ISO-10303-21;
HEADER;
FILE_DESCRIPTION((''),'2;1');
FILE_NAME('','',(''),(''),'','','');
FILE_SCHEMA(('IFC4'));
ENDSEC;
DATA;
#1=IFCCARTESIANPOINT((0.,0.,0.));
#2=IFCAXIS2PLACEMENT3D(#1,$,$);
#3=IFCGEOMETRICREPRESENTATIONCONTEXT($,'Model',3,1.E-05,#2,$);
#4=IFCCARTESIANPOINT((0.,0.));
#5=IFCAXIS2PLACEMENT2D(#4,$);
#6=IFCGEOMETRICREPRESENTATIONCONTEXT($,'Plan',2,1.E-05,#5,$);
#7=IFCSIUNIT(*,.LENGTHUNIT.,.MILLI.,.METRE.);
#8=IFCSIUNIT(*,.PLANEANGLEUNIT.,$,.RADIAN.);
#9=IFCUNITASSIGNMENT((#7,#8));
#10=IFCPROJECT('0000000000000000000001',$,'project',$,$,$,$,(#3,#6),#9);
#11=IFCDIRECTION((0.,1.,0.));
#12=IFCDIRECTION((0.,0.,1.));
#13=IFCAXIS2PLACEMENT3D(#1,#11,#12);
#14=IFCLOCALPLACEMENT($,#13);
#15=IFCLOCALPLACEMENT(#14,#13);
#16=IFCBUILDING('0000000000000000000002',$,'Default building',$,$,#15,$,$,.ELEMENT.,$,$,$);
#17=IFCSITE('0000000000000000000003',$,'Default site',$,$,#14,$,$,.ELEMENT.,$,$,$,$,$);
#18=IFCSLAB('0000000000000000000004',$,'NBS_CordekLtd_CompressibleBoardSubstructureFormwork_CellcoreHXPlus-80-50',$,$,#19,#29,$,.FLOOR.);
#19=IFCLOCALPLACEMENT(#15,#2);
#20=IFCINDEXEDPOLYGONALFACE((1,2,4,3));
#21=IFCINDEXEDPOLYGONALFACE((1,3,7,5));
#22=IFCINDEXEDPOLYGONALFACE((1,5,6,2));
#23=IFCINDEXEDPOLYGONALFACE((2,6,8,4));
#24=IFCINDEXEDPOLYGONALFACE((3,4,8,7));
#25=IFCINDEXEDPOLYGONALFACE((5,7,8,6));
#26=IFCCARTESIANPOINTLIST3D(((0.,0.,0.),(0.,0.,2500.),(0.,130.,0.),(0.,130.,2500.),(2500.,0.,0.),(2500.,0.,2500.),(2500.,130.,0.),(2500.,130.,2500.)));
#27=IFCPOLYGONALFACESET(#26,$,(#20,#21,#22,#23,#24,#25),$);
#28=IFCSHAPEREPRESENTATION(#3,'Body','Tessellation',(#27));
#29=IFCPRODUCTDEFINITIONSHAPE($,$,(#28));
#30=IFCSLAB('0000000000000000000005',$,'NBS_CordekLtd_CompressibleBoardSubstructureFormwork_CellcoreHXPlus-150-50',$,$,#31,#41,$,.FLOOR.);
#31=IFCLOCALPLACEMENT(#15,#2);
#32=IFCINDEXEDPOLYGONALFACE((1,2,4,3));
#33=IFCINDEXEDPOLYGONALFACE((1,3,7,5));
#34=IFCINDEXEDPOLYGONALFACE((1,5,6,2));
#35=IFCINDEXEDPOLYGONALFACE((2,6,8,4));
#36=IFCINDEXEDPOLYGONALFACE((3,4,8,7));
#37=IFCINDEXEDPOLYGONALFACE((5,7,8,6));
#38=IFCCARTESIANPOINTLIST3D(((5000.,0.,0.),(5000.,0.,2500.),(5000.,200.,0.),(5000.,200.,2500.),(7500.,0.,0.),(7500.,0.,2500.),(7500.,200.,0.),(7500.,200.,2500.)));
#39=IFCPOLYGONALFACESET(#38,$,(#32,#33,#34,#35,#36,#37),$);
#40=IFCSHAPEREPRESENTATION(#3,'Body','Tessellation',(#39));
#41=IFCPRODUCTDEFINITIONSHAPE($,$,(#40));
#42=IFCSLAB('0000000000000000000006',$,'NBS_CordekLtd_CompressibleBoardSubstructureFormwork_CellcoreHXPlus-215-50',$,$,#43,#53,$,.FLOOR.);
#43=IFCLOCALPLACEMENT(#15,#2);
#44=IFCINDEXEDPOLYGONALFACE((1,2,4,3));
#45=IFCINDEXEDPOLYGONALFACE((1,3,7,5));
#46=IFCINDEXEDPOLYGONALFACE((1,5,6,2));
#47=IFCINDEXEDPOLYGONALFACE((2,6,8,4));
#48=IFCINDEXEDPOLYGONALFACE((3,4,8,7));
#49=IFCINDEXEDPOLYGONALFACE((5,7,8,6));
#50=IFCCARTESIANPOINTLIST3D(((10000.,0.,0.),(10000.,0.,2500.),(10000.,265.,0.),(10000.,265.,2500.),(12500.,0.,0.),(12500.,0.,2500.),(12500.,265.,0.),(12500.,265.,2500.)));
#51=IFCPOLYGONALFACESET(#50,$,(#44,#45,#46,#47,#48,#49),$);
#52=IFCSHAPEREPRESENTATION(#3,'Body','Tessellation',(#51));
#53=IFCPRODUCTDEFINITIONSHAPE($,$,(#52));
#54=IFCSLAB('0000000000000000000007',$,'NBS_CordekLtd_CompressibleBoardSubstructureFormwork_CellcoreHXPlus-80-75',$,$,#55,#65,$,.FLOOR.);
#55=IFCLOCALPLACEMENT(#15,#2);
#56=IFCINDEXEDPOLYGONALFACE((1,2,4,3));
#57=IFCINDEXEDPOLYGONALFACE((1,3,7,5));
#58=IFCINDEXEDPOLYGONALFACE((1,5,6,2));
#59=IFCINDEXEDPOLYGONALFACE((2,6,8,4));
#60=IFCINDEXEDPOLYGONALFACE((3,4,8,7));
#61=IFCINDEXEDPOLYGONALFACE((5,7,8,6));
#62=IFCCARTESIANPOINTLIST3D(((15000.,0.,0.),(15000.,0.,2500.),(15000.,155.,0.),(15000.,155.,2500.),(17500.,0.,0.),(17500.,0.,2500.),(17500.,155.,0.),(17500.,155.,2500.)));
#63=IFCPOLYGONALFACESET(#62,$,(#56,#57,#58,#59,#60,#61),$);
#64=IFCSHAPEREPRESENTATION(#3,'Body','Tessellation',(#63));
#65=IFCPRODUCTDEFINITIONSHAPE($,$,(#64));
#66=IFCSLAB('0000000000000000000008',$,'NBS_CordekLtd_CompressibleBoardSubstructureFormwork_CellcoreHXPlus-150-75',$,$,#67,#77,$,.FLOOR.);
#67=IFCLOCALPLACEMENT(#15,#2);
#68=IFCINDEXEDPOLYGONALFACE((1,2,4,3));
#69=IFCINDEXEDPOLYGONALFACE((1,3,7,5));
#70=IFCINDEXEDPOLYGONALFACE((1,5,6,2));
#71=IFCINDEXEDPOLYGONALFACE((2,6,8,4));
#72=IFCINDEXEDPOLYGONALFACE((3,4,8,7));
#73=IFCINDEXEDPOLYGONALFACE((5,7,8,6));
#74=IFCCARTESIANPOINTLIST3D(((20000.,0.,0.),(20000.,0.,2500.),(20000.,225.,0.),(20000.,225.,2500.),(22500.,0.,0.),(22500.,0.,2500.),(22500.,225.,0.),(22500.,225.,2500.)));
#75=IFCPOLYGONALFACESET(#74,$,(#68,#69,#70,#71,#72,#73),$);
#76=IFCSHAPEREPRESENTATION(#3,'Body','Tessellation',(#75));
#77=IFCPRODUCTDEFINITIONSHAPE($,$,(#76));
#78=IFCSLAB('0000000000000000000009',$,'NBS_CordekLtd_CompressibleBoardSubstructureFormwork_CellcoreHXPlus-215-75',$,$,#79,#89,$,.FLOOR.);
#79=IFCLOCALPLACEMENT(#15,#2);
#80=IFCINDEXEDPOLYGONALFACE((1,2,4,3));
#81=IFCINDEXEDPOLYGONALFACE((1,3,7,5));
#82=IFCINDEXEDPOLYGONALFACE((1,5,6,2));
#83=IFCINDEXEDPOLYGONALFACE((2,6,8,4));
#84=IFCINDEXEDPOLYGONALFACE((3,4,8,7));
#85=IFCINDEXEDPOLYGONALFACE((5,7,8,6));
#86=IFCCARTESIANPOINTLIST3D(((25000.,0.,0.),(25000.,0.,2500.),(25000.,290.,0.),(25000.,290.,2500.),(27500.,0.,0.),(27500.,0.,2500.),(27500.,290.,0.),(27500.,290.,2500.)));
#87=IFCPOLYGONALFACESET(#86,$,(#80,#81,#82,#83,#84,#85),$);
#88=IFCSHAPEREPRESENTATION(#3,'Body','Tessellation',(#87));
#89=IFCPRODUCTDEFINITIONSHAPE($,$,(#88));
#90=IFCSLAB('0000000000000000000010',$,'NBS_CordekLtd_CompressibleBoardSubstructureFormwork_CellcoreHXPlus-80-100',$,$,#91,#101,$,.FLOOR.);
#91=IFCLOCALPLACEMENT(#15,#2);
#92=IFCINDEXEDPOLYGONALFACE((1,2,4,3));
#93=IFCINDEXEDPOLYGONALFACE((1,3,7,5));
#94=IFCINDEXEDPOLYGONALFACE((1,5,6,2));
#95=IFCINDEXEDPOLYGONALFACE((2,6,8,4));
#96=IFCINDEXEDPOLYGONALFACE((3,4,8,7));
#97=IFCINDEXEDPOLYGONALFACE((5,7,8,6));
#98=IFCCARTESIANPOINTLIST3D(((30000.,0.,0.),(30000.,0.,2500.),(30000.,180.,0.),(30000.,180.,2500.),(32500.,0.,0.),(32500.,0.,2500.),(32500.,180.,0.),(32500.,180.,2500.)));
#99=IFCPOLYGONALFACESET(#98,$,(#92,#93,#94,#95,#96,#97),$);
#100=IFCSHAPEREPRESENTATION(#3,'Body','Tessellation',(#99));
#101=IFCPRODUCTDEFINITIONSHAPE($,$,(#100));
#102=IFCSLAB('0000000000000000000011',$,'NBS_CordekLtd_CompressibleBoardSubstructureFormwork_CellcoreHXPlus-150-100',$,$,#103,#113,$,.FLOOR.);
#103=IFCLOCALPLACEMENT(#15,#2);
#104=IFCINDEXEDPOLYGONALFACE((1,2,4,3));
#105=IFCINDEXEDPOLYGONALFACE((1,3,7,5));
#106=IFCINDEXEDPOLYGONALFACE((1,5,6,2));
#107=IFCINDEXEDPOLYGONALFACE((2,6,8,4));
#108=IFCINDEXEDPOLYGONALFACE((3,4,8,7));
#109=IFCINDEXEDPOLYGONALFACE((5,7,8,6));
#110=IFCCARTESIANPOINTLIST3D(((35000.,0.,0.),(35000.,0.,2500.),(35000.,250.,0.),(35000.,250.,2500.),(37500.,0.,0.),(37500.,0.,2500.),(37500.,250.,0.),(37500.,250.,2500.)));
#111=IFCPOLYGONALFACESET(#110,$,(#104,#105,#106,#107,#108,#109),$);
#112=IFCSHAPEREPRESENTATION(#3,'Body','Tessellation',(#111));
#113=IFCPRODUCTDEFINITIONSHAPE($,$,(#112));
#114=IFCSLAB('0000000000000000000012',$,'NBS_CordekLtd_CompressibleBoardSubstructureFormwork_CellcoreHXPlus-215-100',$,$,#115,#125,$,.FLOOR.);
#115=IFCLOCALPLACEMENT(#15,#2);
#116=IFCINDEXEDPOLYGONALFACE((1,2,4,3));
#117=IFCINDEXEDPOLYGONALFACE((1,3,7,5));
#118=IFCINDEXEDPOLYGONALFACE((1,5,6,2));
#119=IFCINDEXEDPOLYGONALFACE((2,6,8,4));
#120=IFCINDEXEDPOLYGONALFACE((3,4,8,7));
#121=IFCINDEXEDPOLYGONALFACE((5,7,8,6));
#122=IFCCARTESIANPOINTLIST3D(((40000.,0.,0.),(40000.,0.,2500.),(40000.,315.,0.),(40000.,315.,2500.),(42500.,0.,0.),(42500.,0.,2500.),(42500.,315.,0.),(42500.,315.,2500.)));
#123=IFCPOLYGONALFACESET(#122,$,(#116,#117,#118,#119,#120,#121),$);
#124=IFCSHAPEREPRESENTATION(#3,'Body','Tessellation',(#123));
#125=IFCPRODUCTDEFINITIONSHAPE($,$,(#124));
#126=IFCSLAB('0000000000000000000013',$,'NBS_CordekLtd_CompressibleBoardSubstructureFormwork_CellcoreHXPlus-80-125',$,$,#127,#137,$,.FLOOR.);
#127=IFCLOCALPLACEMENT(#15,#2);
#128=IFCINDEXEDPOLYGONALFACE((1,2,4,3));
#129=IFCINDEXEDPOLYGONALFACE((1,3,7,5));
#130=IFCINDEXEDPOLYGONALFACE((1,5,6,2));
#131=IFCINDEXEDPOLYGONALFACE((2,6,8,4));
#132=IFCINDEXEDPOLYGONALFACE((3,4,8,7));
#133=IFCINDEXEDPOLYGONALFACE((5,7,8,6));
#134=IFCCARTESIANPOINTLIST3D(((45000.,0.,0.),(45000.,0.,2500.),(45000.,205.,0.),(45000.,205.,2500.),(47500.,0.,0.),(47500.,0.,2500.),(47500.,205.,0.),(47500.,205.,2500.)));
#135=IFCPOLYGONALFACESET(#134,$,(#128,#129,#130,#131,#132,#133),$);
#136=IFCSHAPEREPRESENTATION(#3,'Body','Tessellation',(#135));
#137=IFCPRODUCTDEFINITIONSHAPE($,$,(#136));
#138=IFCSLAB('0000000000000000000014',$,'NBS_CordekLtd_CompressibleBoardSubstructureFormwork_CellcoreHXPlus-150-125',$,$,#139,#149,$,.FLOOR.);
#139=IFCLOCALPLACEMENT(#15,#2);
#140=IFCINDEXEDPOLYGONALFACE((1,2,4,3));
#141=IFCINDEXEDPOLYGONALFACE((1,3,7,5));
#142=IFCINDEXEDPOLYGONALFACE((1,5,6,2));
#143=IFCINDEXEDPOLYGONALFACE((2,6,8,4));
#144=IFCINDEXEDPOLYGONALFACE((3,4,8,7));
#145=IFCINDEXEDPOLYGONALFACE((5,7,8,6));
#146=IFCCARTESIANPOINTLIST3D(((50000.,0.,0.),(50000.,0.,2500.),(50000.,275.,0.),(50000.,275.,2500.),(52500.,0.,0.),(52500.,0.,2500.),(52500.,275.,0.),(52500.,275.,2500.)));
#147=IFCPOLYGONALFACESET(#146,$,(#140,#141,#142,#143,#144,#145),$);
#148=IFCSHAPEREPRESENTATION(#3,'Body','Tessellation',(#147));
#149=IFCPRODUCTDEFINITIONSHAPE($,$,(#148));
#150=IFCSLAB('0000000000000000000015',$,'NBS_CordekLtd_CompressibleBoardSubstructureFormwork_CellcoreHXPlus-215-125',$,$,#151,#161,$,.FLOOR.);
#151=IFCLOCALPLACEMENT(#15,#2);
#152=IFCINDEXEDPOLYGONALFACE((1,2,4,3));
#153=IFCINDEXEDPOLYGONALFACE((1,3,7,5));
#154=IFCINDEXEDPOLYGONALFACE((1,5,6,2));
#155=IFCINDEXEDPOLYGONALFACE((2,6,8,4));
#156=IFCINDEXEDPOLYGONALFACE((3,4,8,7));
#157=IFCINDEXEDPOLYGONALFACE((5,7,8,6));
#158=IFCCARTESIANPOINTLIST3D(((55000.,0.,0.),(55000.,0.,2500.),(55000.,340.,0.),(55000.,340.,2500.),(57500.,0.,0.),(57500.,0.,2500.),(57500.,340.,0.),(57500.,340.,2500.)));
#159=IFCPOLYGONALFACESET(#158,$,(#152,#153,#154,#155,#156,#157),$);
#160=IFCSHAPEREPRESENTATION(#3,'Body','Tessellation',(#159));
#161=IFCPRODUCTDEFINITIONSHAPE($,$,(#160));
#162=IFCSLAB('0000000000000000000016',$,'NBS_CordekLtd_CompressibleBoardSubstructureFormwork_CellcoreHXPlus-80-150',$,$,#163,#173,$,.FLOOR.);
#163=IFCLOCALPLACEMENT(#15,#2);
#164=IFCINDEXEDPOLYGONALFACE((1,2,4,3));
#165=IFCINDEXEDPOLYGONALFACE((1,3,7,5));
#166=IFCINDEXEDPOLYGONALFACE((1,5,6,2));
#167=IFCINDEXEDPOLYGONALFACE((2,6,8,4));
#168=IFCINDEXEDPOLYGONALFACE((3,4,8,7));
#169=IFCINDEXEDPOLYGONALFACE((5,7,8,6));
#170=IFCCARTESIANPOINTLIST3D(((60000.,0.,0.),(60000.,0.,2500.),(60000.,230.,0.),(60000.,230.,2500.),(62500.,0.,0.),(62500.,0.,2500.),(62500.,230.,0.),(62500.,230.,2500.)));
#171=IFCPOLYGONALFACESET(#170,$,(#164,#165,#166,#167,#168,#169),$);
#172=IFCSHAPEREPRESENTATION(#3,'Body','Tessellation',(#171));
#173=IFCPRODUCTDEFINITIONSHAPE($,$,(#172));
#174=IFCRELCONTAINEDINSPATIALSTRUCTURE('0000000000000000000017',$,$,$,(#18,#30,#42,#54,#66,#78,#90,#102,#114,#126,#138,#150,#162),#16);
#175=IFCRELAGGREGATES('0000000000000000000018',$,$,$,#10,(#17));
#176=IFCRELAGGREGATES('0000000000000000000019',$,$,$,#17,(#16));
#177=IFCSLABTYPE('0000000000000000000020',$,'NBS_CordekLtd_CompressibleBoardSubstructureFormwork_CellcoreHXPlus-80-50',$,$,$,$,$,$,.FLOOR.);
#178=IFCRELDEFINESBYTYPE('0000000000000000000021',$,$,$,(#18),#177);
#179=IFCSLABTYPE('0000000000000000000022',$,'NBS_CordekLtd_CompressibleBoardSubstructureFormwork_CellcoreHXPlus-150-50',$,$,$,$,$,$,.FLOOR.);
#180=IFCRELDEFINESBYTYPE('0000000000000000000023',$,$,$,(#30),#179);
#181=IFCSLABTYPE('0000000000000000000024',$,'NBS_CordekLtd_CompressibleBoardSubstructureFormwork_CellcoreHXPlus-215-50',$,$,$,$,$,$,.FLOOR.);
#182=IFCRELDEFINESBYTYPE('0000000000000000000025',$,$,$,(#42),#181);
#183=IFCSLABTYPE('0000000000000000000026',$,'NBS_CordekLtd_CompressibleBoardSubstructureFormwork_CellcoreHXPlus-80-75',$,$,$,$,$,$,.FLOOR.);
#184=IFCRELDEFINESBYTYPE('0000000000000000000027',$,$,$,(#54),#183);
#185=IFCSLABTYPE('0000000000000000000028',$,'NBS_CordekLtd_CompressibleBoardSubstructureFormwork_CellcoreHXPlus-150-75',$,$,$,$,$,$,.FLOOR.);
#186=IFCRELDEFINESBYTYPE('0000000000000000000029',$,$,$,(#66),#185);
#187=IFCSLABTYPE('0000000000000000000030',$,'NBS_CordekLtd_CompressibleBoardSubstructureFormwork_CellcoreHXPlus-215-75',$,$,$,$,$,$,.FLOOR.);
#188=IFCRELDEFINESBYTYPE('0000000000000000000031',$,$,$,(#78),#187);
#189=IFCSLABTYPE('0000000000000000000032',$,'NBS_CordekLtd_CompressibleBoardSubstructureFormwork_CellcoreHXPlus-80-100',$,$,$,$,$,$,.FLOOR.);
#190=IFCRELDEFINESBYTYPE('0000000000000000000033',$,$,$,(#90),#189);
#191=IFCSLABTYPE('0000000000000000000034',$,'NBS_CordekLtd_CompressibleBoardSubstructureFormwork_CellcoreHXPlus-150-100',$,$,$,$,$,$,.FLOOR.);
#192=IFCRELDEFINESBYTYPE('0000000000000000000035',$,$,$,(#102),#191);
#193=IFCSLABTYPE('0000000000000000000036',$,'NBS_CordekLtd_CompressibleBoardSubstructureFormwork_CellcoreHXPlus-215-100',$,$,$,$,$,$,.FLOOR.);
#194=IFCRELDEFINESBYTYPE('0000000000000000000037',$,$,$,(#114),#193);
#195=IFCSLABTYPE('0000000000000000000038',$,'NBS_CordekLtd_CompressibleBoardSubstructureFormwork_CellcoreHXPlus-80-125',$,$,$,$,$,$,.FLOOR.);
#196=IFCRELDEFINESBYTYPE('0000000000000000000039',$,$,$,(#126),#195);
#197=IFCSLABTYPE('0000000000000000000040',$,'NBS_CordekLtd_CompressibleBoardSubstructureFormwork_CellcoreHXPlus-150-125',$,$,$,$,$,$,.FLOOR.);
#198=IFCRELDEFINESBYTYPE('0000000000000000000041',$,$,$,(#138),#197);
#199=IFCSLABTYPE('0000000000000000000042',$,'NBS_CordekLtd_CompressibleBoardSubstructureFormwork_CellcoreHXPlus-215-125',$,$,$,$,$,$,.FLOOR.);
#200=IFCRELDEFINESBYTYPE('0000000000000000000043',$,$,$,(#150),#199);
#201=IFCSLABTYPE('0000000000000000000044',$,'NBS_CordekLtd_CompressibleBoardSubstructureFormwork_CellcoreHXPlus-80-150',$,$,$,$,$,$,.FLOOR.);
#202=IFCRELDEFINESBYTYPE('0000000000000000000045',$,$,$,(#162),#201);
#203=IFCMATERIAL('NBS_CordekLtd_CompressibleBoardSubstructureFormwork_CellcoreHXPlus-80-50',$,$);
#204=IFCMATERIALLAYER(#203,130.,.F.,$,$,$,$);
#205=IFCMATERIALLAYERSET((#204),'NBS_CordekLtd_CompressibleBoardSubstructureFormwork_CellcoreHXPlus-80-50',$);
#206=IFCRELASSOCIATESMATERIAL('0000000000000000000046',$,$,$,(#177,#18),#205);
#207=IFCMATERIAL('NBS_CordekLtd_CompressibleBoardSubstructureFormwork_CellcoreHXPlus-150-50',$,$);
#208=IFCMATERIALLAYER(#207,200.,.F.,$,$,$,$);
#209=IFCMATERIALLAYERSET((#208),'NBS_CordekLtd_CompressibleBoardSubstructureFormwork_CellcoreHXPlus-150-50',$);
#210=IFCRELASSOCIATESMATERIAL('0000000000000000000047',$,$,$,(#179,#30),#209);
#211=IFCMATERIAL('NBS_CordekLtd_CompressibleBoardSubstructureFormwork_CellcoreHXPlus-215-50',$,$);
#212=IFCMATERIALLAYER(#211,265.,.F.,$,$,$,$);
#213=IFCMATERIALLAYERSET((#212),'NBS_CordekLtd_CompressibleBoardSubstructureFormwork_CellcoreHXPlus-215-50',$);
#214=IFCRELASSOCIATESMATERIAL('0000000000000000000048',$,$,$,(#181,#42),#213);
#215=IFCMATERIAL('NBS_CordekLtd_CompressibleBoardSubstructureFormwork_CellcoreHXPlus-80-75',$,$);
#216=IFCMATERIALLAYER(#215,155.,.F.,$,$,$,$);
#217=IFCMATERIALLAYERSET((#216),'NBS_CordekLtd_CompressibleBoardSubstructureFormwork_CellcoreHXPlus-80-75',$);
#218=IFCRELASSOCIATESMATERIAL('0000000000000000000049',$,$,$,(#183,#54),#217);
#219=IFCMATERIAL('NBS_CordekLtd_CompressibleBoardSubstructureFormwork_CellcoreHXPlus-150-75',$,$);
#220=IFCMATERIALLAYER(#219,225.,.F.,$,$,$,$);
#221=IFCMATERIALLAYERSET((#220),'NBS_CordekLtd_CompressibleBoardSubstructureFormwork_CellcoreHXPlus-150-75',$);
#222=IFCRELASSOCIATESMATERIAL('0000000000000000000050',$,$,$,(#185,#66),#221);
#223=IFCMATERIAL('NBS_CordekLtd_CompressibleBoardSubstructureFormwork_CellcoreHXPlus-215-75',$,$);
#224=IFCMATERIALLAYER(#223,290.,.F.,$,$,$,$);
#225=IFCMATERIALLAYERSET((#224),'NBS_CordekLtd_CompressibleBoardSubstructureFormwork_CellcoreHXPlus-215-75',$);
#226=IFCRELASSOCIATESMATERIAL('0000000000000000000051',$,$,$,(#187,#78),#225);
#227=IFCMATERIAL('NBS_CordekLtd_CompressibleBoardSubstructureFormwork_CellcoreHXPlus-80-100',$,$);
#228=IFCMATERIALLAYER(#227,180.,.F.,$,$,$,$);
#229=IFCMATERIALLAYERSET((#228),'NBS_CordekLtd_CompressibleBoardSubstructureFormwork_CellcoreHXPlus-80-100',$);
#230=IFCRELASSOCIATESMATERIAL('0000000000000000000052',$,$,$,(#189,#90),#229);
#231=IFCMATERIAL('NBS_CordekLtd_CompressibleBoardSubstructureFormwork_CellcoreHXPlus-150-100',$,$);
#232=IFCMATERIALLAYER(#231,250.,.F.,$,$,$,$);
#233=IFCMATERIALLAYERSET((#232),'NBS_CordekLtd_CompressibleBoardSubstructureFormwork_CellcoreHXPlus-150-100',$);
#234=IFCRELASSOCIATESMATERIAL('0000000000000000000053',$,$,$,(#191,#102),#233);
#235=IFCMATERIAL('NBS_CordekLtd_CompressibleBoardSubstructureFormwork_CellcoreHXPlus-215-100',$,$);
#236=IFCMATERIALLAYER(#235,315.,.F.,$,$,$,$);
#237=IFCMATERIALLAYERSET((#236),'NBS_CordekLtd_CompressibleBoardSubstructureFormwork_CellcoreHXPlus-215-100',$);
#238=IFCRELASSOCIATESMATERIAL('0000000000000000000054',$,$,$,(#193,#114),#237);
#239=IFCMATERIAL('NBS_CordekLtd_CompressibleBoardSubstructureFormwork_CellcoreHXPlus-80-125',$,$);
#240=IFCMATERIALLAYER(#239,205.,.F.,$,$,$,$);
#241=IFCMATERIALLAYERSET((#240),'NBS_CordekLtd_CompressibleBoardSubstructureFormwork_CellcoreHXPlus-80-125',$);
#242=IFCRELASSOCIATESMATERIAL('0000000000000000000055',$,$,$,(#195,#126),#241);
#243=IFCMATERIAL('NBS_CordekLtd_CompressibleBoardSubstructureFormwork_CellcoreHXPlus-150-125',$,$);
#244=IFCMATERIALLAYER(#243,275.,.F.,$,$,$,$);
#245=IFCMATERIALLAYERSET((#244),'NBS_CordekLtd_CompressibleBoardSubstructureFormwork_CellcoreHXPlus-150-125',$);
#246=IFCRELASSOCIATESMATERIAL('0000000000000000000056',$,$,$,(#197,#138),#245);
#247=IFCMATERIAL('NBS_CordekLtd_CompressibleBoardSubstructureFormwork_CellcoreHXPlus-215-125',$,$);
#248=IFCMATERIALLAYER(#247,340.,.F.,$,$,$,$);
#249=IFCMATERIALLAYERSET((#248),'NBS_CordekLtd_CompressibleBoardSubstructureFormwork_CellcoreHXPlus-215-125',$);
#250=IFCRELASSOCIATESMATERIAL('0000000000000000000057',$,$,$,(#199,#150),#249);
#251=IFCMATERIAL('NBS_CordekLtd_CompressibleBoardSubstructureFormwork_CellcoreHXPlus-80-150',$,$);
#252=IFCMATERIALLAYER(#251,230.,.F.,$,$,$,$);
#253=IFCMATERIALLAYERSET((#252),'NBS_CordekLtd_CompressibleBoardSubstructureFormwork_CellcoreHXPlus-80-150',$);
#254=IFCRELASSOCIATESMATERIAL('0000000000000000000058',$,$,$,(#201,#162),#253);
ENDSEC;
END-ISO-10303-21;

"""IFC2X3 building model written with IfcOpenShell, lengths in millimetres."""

from ifc_helpers import new_model, si_unit, frame, frame_2d, origin, origin_with_axes, origin_2d, place, context, project, spatial, rectangle, extrude, material, layer, layer_set, layer_usage, type_object, element, save


model = new_model("IFC2X3")

# Units and contexts
model_context = context("Model", 3, precision=1e-05, world=origin())
plan_context = context("Plan", 2, precision=1e-05, world=origin_2d())
ifc_project = project(units=[si_unit("LENGTHUNIT", "METRE", prefix="MILLI"), si_unit("PLANEANGLEUNIT", "RADIAN")], contexts=[model_context, plan_context])

# Site, building
site_placement = place(None, frame((0.0, 0.0, 0.0), z_axis=(0.0, 1.0, 0.0), x_axis=(0.0, 0.0, 1.0)))
site = spatial("IfcSite", under=ifc_project, at=site_placement, Name="Default site", CompositionType="ELEMENT")
building_placement = place(site_placement, frame((0.0, 0.0, 0.0), z_axis=(0.0, 1.0, 0.0), x_axis=(0.0, 0.0, 1.0)))
building = spatial("IfcBuilding", under=site, at=building_placement, Name="Default building", CompositionType="ELEMENT")

# Slabs
ifc_material_1 = material(Name="NBS_CordekLtd_CompressibleBoardSubstructureFormwork_CellcoreHXPlus-80-50")
ifc_layer_1 = layer(ifc_material_1, 130.0, ventilated=False)
ifc_layer_set_1 = layer_set([ifc_layer_1], Name="NBS_CordekLtd_CompressibleBoardSubstructureFormwork_CellcoreHXPlus-80-50")
ifc_layer_usage_1 = layer_usage(ifc_layer_set_1, "AXIS3", "NEGATIVE", 0.0)
slab_type_1 = type_object("IfcSlabType", Name="NBS_CordekLtd_CompressibleBoardSubstructureFormwork_CellcoreHXPlus-80-50", PredefinedType="FLOOR", material=ifc_layer_set_1)
slab_1_placement = place(None, origin())
element("IfcSlab", 1, at=slab_1_placement, inside=building, type_object=slab_type_1, material=ifc_layer_usage_1, Name="NBS_CordekLtd_CompressibleBoardSubstructureFormwork_CellcoreHXPlus-80-50", PredefinedType="FLOOR", context=model_context, shape_type="SweptSolid", body=[
    extrude(rectangle(XDim=2500.0, YDim=2500.0, at=frame_2d((1250.0, 1250.0))), origin_with_axes(), (0.0, 0.0, 1.0), 130.0),
])
ifc_material_2 = material(Name="NBS_CordekLtd_CompressibleBoardSubstructureFormwork_CellcoreHXPlus-150-50")
ifc_layer_2 = layer(ifc_material_2, 200.0, ventilated=False)
ifc_layer_set_2 = layer_set([ifc_layer_2], Name="NBS_CordekLtd_CompressibleBoardSubstructureFormwork_CellcoreHXPlus-150-50")
ifc_layer_usage_2 = layer_usage(ifc_layer_set_2, "AXIS3", "NEGATIVE", 0.0)
slab_type_2 = type_object("IfcSlabType", Name="NBS_CordekLtd_CompressibleBoardSubstructureFormwork_CellcoreHXPlus-150-50", PredefinedType="FLOOR", material=ifc_layer_set_2)
slab_2_placement = place(None, frame((0.0, 5000.0, 0.0)))
element("IfcSlab", 2, at=slab_2_placement, inside=building, type_object=slab_type_2, material=ifc_layer_usage_2, Name="NBS_CordekLtd_CompressibleBoardSubstructureFormwork_CellcoreHXPlus-150-50", PredefinedType="FLOOR", context=model_context, shape_type="SweptSolid", body=[
    extrude(rectangle(XDim=2500.0, YDim=2500.0, at=frame_2d((1250.0, 1250.0))), origin_with_axes(), (0.0, 0.0, 1.0), 200.0),
])
ifc_material_3 = material(Name="NBS_CordekLtd_CompressibleBoardSubstructureFormwork_CellcoreHXPlus-215-50")
ifc_layer_3 = layer(ifc_material_3, 265.0, ventilated=False)
ifc_layer_set_3 = layer_set([ifc_layer_3], Name="NBS_CordekLtd_CompressibleBoardSubstructureFormwork_CellcoreHXPlus-215-50")
ifc_layer_usage_3 = layer_usage(ifc_layer_set_3, "AXIS3", "NEGATIVE", 0.0)
slab_type_3 = type_object("IfcSlabType", Name="NBS_CordekLtd_CompressibleBoardSubstructureFormwork_CellcoreHXPlus-215-50", PredefinedType="FLOOR", material=ifc_layer_set_3)
slab_3_placement = place(None, frame((0.0, 10000.0, 0.0)))
element("IfcSlab", 3, at=slab_3_placement, inside=building, type_object=slab_type_3, material=ifc_layer_usage_3, Name="NBS_CordekLtd_CompressibleBoardSubstructureFormwork_CellcoreHXPlus-215-50", PredefinedType="FLOOR", context=model_context, shape_type="SweptSolid", body=[
    extrude(rectangle(XDim=2500.0, YDim=2500.0, at=frame_2d((1250.0, 1250.0))), origin_with_axes(), (0.0, 0.0, 1.0), 265.0),
])
ifc_material_4 = material(Name="NBS_CordekLtd_CompressibleBoardSubstructureFormwork_CellcoreHXPlus-80-75")
ifc_layer_4 = layer(ifc_material_4, 155.0, ventilated=False)
ifc_layer_set_4 = layer_set([ifc_layer_4], Name="NBS_CordekLtd_CompressibleBoardSubstructureFormwork_CellcoreHXPlus-80-75")
ifc_layer_usage_4 = layer_usage(ifc_layer_set_4, "AXIS3", "NEGATIVE", 0.0)
slab_type_4 = type_object("IfcSlabType", Name="NBS_CordekLtd_CompressibleBoardSubstructureFormwork_CellcoreHXPlus-80-75", PredefinedType="FLOOR", material=ifc_layer_set_4)
slab_4_placement = place(None, frame((0.0, 15000.0, 0.0)))
element("IfcSlab", 4, at=slab_4_placement, inside=building, type_object=slab_type_4, material=ifc_layer_usage_4, Name="NBS_CordekLtd_CompressibleBoardSubstructureFormwork_CellcoreHXPlus-80-75", PredefinedType="FLOOR", context=model_context, shape_type="SweptSolid", body=[
    extrude(rectangle(XDim=2500.0, YDim=2500.0, at=frame_2d((1250.0, 1250.0))), origin_with_axes(), (0.0, 0.0, 1.0), 155.0),
])
ifc_material_5 = material(Name="NBS_CordekLtd_CompressibleBoardSubstructureFormwork_CellcoreHXPlus-150-75")
ifc_layer_5 = layer(ifc_material_5, 225.0, ventilated=False)
ifc_layer_set_5 = layer_set([ifc_layer_5], Name="NBS_CordekLtd_CompressibleBoardSubstructureFormwork_CellcoreHXPlus-150-75")
ifc_layer_usage_5 = layer_usage(ifc_layer_set_5, "AXIS3", "NEGATIVE", 0.0)
slab_type_5 = type_object("IfcSlabType", Name="NBS_CordekLtd_CompressibleBoardSubstructureFormwork_CellcoreHXPlus-150-75", PredefinedType="FLOOR", material=ifc_layer_set_5)
slab_5_placement = place(None, frame((0.0, 20000.0, 0.0)))
element("IfcSlab", 5, at=slab_5_placement, inside=building, type_object=slab_type_5, material=ifc_layer_usage_5, Name="NBS_CordekLtd_CompressibleBoardSubstructureFormwork_CellcoreHXPlus-150-75", PredefinedType="FLOOR", context=model_context, shape_type="SweptSolid", body=[
    extrude(rectangle(XDim=2500.0, YDim=2500.0, at=frame_2d((1250.0, 1250.0))), origin_with_axes(), (0.0, 0.0, 1.0), 225.0),
])
ifc_material_6 = material(Name="NBS_CordekLtd_CompressibleBoardSubstructureFormwork_CellcoreHXPlus-215-75")
ifc_layer_6 = layer(ifc_material_6, 290.0, ventilated=False)
ifc_layer_set_6 = layer_set([ifc_layer_6], Name="NBS_CordekLtd_CompressibleBoardSubstructureFormwork_CellcoreHXPlus-215-75")
ifc_layer_usage_6 = layer_usage(ifc_layer_set_6, "AXIS3", "NEGATIVE", 0.0)
slab_type_6 = type_object("IfcSlabType", Name="NBS_CordekLtd_CompressibleBoardSubstructureFormwork_CellcoreHXPlus-215-75", PredefinedType="FLOOR", material=ifc_layer_set_6)
slab_6_placement = place(None, frame((0.0, 25000.0, 0.0)))
element("IfcSlab", 6, at=slab_6_placement, inside=building, type_object=slab_type_6, material=ifc_layer_usage_6, Name="NBS_CordekLtd_CompressibleBoardSubstructureFormwork_CellcoreHXPlus-215-75", PredefinedType="FLOOR", context=model_context, shape_type="SweptSolid", body=[
    extrude(rectangle(XDim=2500.0, YDim=2500.0, at=frame_2d((1250.0, 1250.0))), origin_with_axes(), (0.0, 0.0, 1.0), 290.0),
])
ifc_material_7 = material(Name="NBS_CordekLtd_CompressibleBoardSubstructureFormwork_CellcoreHXPlus-80-100")
ifc_layer_7 = layer(ifc_material_7, 180.0, ventilated=False)
ifc_layer_set_7 = layer_set([ifc_layer_7], Name="NBS_CordekLtd_CompressibleBoardSubstructureFormwork_CellcoreHXPlus-80-100")
ifc_layer_usage_7 = layer_usage(ifc_layer_set_7, "AXIS3", "NEGATIVE", 0.0)
slab_type_7 = type_object("IfcSlabType", Name="NBS_CordekLtd_CompressibleBoardSubstructureFormwork_CellcoreHXPlus-80-100", PredefinedType="FLOOR", material=ifc_layer_set_7)
slab_7_placement = place(None, frame((0.0, 30000.0, 0.0)))
element("IfcSlab", 7, at=slab_7_placement, inside=building, type_object=slab_type_7, material=ifc_layer_usage_7, Name="NBS_CordekLtd_CompressibleBoardSubstructureFormwork_CellcoreHXPlus-80-100", PredefinedType="FLOOR", context=model_context, shape_type="SweptSolid", body=[
    extrude(rectangle(XDim=2500.0, YDim=2500.0, at=frame_2d((1250.0, 1250.0))), origin_with_axes(), (0.0, 0.0, 1.0), 180.0),
])
ifc_material_8 = material(Name="NBS_CordekLtd_CompressibleBoardSubstructureFormwork_CellcoreHXPlus-150-100")
ifc_layer_8 = layer(ifc_material_8, 250.0, ventilated=False)
ifc_layer_set_8 = layer_set([ifc_layer_8], Name="NBS_CordekLtd_CompressibleBoardSubstructureFormwork_CellcoreHXPlus-150-100")
ifc_layer_usage_8 = layer_usage(ifc_layer_set_8, "AXIS3", "NEGATIVE", 0.0)
slab_type_8 = type_object("IfcSlabType", Name="NBS_CordekLtd_CompressibleBoardSubstructureFormwork_CellcoreHXPlus-150-100", PredefinedType="FLOOR", material=ifc_layer_set_8)
slab_8_placement = place(None, frame((0.0, 35000.0, 0.0)))
element("IfcSlab", 8, at=slab_8_placement, inside=building, type_object=slab_type_8, material=ifc_layer_usage_8, Name="NBS_CordekLtd_CompressibleBoardSubstructureFormwork_CellcoreHXPlus-150-100", PredefinedType="FLOOR", context=model_context, shape_type="SweptSolid", body=[
    extrude(rectangle(XDim=2500.0, YDim=2500.0, at=frame_2d((1250.0, 1250.0))), origin_with_axes(), (0.0, 0.0, 1.0), 250.0),
])
ifc_material_9 = material(Name="NBS_CordekLtd_CompressibleBoardSubstructureFormwork_CellcoreHXPlus-215-100")
ifc_layer_9 = layer(ifc_material_9, 315.0, ventilated=False)
ifc_layer_set_9 = layer_set([ifc_layer_9], Name="NBS_CordekLtd_CompressibleBoardSubstructureFormwork_CellcoreHXPlus-215-100")
ifc_layer_usage_9 = layer_usage(ifc_layer_set_9, "AXIS3", "NEGATIVE", 0.0)
slab_type_9 = type_object("IfcSlabType", Name="NBS_CordekLtd_CompressibleBoardSubstructureFormwork_CellcoreHXPlus-215-100", PredefinedType="FLOOR", material=ifc_layer_set_9)
slab_9_placement = place(None, frame((0.0, 40000.0, 0.0)))
element("IfcSlab", 9, at=slab_9_placement, inside=building, type_object=slab_type_9, material=ifc_layer_usage_9, Name="NBS_CordekLtd_CompressibleBoardSubstructureFormwork_CellcoreHXPlus-215-100", PredefinedType="FLOOR", context=model_context, shape_type="SweptSolid", body=[
    extrude(rectangle(XDim=2500.0, YDim=2500.0, at=frame_2d((1250.0, 1250.0))), origin_with_axes(), (0.0, 0.0, 1.0), 315.0),
])
ifc_material_10 = material(Name="NBS_CordekLtd_CompressibleBoardSubstructureFormwork_CellcoreHXPlus-80-125")
ifc_layer_10 = layer(ifc_material_10, 205.0, ventilated=False)
ifc_layer_set_10 = layer_set([ifc_layer_10], Name="NBS_CordekLtd_CompressibleBoardSubstructureFormwork_CellcoreHXPlus-80-125")
ifc_layer_usage_10 = layer_usage(ifc_layer_set_10, "AXIS3", "NEGATIVE", 0.0)
slab_type_10 = type_object("IfcSlabType", Name="NBS_CordekLtd_CompressibleBoardSubstructureFormwork_CellcoreHXPlus-80-125", PredefinedType="FLOOR", material=ifc_layer_set_10)
slab_10_placement = place(None, frame((0.0, 45000.0, 0.0)))
element("IfcSlab", 10, at=slab_10_placement, inside=building, type_object=slab_type_10, material=ifc_layer_usage_10, Name="NBS_CordekLtd_CompressibleBoardSubstructureFormwork_CellcoreHXPlus-80-125", PredefinedType="FLOOR", context=model_context, shape_type="SweptSolid", body=[
    extrude(rectangle(XDim=2500.0, YDim=2500.0, at=frame_2d((1250.0, 1250.0))), origin_with_axes(), (0.0, 0.0, 1.0), 205.0),
])
ifc_material_11 = material(Name="NBS_CordekLtd_CompressibleBoardSubstructureFormwork_CellcoreHXPlus-150-125")
ifc_layer_11 = layer(ifc_material_11, 275.0, ventilated=False)
ifc_layer_set_11 = layer_set([ifc_layer_11], Name="NBS_CordekLtd_CompressibleBoardSubstructureFormwork_CellcoreHXPlus-150-125")
ifc_layer_usage_11 = layer_usage(ifc_layer_set_11, "AXIS3", "NEGATIVE", 0.0)
slab_type_11 = type_object("IfcSlabType", Name="NBS_CordekLtd_CompressibleBoardSubstructureFormwork_CellcoreHXPlus-150-125", PredefinedType="FLOOR", material=ifc_layer_set_11)
slab_11_placement = place(None, frame((0.0, 50000.0, 0.0)))
element("IfcSlab", 11, at=slab_11_placement, inside=building, type_object=slab_type_11, material=ifc_layer_usage_11, Name="NBS_CordekLtd_CompressibleBoardSubstructureFormwork_CellcoreHXPlus-150-125", PredefinedType="FLOOR", context=model_context, shape_type="SweptSolid", body=[
    extrude(rectangle(XDim=2500.0, YDim=2500.0, at=frame_2d((1250.0, 1250.0))), origin_with_axes(), (0.0, 0.0, 1.0), 275.0),
])
ifc_material_12 = material(Name="NBS_CordekLtd_CompressibleBoardSubstructureFormwork_CellcoreHXPlus-215-125")
ifc_layer_12 = layer(ifc_material_12, 340.0, ventilated=False)
ifc_layer_set_12 = layer_set([ifc_layer_12], Name="NBS_CordekLtd_CompressibleBoardSubstructureFormwork_CellcoreHXPlus-215-125")
ifc_layer_usage_12 = layer_usage(ifc_layer_set_12, "AXIS3", "NEGATIVE", 0.0)
slab_type_12 = type_object("IfcSlabType", Name="NBS_CordekLtd_CompressibleBoardSubstructureFormwork_CellcoreHXPlus-215-125", PredefinedType="FLOOR", material=ifc_layer_set_12)
slab_12_placement = place(None, frame((0.0, 55000.0, 0.0)))
element("IfcSlab", 12, at=slab_12_placement, inside=building, type_object=slab_type_12, material=ifc_layer_usage_12, Name="NBS_CordekLtd_CompressibleBoardSubstructureFormwork_CellcoreHXPlus-215-125", PredefinedType="FLOOR", context=model_context, shape_type="SweptSolid", body=[
    extrude(rectangle(XDim=2500.0, YDim=2500.0, at=frame_2d((1250.0, 1250.0))), origin_with_axes(), (0.0, 0.0, 1.0), 340.0),
])
ifc_material_13 = material(Name="NBS_CordekLtd_CompressibleBoardSubstructureFormwork_CellcoreHXPlus-80-150")
ifc_layer_13 = layer(ifc_material_13, 230.0, ventilated=False)
ifc_layer_set_13 = layer_set([ifc_layer_13], Name="NBS_CordekLtd_CompressibleBoardSubstructureFormwork_CellcoreHXPlus-80-150")
ifc_layer_usage_13 = layer_usage(ifc_layer_set_13, "AXIS3", "NEGATIVE", 0.0)
slab_type_13 = type_object("IfcSlabType", Name="NBS_CordekLtd_CompressibleBoardSubstructureFormwork_CellcoreHXPlus-80-150", PredefinedType="FLOOR", material=ifc_layer_set_13)
slab_13_placement = place(None, frame((0.0, 60000.0, 0.0)))
element("IfcSlab", 13, at=slab_13_placement, inside=building, type_object=slab_type_13, material=ifc_layer_usage_13, Name="NBS_CordekLtd_CompressibleBoardSubstructureFormwork_CellcoreHXPlus-80-150", PredefinedType="FLOOR", context=model_context, shape_type="SweptSolid", body=[
    extrude(rectangle(XDim=2500.0, YDim=2500.0, at=frame_2d((1250.0, 1250.0))), origin_with_axes(), (0.0, 0.0, 1.0), 230.0),
])

save(model, "model.ifc")
